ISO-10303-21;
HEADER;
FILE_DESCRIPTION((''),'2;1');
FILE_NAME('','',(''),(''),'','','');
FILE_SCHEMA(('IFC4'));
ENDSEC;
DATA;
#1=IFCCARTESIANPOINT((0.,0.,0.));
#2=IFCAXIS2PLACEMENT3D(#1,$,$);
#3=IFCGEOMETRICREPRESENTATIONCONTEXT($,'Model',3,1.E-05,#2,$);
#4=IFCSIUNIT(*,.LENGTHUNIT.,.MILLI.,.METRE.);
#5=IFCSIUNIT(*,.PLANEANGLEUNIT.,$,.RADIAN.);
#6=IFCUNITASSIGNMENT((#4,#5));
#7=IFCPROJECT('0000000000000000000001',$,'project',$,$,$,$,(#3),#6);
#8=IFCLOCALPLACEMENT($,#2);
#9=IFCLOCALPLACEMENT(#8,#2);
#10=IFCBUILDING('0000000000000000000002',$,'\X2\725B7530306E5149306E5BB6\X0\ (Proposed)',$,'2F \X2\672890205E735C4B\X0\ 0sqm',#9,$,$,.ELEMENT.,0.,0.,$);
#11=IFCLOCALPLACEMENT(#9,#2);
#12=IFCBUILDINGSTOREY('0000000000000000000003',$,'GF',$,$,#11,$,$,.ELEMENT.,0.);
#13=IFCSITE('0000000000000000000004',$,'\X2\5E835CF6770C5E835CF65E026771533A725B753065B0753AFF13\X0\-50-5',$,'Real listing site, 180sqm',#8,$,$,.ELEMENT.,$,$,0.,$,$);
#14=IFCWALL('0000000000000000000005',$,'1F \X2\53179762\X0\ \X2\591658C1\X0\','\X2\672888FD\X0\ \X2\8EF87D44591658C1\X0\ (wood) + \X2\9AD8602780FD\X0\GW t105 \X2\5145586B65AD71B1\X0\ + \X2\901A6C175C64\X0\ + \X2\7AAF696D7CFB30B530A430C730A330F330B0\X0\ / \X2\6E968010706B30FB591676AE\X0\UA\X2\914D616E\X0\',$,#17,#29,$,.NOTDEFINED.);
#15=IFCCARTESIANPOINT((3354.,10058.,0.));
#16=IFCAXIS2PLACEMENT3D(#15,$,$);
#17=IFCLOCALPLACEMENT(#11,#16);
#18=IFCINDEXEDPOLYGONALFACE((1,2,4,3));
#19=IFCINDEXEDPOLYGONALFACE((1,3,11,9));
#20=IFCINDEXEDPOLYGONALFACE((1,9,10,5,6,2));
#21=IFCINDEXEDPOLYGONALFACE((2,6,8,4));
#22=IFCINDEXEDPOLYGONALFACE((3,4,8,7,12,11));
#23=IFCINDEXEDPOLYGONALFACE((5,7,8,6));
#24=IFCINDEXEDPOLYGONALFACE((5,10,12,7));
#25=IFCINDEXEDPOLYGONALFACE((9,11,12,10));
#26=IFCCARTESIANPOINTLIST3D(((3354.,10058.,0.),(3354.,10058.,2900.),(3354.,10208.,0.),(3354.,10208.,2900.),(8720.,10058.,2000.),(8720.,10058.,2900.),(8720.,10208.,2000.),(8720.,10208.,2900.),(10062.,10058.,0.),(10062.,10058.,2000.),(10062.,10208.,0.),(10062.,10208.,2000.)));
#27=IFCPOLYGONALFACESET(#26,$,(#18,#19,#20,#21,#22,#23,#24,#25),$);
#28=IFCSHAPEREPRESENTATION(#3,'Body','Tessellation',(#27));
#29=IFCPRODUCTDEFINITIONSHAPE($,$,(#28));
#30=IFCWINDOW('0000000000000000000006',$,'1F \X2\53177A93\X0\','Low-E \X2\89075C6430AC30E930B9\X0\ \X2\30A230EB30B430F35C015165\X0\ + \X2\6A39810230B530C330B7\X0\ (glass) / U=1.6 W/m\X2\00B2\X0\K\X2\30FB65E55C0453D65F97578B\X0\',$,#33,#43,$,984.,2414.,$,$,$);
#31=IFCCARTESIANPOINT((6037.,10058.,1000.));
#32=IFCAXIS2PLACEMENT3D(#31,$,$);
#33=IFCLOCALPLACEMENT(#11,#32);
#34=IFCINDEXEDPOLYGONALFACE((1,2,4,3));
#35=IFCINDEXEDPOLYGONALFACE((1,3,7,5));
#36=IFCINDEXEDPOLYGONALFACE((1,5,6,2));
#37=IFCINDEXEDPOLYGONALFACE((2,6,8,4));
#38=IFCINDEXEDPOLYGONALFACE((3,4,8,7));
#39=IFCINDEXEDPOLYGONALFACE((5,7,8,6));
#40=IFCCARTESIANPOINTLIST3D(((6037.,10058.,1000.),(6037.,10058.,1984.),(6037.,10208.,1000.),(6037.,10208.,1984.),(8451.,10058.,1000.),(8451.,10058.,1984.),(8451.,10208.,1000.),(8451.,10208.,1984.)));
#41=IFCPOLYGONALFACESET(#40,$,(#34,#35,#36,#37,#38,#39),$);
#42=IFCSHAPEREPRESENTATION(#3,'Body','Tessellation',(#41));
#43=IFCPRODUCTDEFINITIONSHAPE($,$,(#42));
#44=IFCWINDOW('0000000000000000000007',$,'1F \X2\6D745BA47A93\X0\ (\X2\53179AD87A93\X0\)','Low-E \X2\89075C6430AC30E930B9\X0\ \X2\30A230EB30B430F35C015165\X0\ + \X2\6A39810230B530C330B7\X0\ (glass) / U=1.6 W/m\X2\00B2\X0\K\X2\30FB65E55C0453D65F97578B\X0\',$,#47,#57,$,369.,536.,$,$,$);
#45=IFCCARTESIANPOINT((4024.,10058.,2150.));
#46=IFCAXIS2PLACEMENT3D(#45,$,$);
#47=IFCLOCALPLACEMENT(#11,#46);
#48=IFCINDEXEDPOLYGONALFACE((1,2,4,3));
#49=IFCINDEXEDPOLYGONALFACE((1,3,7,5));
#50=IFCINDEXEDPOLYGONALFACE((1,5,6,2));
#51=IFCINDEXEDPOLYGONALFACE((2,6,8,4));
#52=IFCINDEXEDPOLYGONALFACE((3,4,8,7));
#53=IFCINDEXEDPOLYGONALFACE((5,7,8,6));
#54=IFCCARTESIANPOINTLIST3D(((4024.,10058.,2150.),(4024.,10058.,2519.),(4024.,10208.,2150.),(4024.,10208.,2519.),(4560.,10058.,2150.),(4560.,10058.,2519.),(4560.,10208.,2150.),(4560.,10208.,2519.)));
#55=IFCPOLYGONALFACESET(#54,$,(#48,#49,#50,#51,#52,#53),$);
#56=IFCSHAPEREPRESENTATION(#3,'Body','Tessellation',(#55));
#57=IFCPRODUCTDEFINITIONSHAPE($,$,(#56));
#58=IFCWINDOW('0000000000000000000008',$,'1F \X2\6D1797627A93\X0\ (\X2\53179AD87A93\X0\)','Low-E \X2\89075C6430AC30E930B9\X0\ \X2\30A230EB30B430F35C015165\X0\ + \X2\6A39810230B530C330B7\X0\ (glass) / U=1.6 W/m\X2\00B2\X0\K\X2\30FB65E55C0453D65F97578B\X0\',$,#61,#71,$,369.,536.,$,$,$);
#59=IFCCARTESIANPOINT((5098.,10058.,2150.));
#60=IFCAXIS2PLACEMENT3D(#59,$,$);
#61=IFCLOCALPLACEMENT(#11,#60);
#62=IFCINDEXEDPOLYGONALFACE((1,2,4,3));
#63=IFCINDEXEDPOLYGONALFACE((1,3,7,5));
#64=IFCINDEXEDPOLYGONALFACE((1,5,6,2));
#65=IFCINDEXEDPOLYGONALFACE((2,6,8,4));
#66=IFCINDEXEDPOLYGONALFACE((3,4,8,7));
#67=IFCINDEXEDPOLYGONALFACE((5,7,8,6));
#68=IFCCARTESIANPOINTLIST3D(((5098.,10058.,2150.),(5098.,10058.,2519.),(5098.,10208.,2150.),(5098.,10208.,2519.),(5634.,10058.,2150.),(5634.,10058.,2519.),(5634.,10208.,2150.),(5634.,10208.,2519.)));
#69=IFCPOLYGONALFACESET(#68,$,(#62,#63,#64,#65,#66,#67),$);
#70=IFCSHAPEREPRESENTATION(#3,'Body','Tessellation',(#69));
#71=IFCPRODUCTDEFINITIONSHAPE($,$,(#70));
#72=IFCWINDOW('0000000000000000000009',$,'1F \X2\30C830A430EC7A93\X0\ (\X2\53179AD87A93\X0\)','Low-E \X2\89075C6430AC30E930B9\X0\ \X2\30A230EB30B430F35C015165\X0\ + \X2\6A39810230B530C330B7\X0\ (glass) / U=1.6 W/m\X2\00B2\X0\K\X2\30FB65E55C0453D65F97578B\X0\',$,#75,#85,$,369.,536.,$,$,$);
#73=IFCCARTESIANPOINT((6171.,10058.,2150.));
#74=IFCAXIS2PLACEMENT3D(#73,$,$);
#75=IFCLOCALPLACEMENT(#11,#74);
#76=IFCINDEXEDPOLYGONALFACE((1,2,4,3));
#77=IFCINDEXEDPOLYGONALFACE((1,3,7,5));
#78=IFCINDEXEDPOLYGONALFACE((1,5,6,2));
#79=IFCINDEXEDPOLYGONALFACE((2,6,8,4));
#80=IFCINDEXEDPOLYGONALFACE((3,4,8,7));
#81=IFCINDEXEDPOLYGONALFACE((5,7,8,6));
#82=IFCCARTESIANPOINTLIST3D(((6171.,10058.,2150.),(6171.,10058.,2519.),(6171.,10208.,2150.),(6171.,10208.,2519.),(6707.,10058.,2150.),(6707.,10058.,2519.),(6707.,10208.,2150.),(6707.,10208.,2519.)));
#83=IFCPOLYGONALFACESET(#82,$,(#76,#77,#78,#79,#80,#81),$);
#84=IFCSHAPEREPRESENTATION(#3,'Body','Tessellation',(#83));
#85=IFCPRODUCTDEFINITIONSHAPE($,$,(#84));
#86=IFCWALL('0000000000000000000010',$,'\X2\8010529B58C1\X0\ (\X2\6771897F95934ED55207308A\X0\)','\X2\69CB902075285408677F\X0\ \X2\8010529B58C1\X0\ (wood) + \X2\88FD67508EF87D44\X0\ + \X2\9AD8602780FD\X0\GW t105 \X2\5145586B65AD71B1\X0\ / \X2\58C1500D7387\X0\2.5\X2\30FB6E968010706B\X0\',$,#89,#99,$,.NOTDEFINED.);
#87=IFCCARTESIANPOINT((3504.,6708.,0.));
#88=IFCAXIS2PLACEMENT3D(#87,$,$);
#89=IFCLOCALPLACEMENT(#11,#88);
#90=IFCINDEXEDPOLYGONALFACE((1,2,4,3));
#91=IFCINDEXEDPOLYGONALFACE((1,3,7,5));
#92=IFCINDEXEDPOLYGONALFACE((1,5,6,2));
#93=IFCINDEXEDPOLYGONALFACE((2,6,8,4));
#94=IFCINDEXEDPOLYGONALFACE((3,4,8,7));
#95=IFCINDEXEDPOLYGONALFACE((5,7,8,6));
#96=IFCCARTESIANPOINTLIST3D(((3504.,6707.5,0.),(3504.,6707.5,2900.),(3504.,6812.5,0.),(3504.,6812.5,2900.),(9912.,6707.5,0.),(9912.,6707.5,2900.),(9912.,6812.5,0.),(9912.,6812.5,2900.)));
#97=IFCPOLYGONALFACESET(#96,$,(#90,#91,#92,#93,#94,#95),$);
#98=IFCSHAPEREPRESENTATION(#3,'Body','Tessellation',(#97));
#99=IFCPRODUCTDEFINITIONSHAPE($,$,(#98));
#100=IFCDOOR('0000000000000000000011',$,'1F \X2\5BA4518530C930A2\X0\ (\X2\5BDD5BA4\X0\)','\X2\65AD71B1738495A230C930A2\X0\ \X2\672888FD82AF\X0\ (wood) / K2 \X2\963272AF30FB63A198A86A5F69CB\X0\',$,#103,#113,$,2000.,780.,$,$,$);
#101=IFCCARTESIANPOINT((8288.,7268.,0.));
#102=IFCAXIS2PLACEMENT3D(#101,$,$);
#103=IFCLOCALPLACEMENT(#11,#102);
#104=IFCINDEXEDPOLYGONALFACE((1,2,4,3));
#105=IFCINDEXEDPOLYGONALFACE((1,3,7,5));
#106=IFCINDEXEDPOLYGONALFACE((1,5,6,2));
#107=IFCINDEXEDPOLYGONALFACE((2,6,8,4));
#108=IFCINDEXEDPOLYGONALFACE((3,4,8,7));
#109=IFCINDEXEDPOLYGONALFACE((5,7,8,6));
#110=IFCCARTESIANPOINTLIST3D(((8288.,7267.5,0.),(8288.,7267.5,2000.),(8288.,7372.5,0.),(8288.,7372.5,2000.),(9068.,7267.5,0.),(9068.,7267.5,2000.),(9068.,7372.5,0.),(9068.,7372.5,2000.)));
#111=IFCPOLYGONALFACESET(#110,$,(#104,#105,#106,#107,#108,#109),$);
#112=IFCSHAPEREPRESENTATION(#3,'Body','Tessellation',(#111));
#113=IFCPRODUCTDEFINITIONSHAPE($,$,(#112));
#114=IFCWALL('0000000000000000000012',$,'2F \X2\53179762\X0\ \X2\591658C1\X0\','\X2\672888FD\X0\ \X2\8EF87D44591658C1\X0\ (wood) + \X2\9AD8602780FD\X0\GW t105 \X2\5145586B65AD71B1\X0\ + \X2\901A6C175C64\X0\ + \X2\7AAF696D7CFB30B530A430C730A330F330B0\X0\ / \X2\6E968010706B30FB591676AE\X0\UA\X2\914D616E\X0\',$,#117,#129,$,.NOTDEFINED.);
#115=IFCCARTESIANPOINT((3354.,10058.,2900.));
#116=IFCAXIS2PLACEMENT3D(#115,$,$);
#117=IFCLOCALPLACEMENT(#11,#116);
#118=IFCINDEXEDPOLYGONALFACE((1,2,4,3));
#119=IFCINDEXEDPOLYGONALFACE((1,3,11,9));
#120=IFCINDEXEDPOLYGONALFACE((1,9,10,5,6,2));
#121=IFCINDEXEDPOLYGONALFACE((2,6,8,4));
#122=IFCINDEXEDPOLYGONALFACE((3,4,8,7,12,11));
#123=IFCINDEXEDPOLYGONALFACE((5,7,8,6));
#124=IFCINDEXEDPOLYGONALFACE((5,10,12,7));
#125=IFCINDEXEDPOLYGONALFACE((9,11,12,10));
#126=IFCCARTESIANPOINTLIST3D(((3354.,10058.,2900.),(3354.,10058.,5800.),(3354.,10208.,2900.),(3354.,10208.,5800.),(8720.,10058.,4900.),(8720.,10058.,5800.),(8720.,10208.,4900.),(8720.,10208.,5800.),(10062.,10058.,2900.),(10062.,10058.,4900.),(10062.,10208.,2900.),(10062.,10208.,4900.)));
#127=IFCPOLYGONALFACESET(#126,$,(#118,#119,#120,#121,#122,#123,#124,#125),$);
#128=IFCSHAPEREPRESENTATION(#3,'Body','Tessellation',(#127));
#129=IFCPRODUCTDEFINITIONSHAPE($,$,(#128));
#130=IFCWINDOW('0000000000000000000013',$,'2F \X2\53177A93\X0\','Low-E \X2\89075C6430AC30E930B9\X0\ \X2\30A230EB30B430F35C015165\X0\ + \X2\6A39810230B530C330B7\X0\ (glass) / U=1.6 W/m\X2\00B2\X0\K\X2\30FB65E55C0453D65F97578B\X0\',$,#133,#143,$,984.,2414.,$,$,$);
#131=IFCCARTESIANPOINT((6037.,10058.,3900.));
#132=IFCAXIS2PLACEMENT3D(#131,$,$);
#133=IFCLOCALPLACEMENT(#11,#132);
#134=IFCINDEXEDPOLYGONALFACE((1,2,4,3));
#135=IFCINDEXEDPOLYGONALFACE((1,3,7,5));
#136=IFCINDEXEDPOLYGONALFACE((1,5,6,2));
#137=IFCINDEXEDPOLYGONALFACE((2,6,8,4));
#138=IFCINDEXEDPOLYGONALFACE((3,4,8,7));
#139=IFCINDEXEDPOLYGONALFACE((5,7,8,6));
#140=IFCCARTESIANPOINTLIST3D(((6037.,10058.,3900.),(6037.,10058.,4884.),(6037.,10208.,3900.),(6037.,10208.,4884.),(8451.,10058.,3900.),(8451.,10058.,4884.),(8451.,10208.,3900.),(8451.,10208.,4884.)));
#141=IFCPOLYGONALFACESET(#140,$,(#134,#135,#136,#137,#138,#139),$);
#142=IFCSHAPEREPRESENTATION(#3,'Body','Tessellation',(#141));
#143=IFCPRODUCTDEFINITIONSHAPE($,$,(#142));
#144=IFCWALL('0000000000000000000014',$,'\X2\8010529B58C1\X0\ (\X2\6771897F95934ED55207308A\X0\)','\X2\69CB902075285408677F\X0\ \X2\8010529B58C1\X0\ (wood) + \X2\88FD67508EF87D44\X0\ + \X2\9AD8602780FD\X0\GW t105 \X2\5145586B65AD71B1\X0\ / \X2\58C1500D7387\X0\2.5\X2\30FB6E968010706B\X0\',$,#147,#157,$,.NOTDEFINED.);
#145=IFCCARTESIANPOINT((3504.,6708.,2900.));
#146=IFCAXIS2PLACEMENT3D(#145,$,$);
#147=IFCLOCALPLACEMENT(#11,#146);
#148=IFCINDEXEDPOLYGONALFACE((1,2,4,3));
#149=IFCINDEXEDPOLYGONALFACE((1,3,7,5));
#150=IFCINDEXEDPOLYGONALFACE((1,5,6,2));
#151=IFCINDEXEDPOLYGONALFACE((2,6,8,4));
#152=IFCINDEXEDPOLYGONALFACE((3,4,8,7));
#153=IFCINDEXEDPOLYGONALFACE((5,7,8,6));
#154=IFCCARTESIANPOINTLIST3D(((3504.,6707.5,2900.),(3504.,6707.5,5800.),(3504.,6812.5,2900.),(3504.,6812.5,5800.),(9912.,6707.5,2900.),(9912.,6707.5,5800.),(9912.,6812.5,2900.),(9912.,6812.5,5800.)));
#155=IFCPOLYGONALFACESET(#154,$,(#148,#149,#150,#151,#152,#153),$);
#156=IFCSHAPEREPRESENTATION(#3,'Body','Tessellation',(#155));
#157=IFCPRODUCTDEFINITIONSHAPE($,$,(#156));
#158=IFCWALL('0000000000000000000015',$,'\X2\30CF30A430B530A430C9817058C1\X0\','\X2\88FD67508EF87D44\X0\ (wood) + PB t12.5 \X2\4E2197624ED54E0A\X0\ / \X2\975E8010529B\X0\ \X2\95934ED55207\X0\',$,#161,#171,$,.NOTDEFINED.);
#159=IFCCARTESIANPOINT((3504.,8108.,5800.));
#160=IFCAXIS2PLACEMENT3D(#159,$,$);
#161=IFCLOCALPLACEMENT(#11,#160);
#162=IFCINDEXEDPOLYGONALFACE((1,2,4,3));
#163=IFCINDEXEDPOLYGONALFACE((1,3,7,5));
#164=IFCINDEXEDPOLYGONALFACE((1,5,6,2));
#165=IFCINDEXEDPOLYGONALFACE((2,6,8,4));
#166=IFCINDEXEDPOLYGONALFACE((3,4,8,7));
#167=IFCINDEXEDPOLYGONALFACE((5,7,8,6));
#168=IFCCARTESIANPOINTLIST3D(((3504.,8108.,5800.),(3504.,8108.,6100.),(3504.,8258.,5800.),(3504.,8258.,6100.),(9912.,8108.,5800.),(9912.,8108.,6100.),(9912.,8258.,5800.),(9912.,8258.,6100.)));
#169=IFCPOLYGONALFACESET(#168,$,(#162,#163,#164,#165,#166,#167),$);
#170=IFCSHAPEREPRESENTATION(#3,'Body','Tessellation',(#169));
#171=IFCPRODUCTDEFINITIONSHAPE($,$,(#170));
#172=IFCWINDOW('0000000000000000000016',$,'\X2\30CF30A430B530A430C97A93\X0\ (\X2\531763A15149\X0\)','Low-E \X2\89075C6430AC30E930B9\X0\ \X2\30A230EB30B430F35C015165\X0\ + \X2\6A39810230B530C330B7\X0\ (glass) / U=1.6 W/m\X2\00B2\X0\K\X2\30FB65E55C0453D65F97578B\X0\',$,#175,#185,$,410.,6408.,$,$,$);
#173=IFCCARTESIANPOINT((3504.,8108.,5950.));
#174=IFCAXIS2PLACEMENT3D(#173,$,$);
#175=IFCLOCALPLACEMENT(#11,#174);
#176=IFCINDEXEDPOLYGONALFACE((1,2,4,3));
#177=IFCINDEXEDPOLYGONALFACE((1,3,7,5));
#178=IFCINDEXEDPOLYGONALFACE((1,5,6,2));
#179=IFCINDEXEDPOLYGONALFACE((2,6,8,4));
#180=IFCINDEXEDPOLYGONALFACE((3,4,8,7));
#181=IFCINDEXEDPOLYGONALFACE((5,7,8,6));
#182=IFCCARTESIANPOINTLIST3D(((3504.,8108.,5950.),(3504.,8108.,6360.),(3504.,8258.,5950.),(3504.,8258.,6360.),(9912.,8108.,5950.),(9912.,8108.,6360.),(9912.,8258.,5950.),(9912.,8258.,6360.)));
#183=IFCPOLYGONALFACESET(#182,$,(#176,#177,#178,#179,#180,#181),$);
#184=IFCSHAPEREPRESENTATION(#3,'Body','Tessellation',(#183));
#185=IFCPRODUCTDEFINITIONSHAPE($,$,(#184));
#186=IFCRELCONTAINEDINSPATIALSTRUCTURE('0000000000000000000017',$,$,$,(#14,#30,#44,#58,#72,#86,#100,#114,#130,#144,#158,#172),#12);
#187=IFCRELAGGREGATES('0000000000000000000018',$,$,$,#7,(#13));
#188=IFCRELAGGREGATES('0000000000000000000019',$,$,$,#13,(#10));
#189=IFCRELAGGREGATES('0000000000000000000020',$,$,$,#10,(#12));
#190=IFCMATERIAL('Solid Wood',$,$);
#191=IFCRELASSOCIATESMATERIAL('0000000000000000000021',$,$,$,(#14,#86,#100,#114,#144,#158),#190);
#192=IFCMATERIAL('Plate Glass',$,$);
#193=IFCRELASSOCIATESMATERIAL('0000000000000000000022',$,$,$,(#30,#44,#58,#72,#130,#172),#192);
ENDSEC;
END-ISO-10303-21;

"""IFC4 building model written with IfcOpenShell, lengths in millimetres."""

from ifc_helpers import new_model, si_unit, frame, frame_2d, origin, place, context, project, spatial, rectangle, extrude, material, element, fill, save


model = new_model("IFC4")

# Units and contexts
model_context = context("Model", 3, precision=1e-05, world=origin())
ifc_project = project(units=[si_unit("LENGTHUNIT", "METRE", prefix="MILLI"), si_unit("PLANEANGLEUNIT", "RADIAN")], contexts=[model_context])

# Site, building, storey
site_placement = place(None, origin())
site = spatial("IfcSite", under=ifc_project, at=site_placement, Name="広島県広島市東区牛田新町３-50-5", ObjectType="Real listing site, 180sqm", CompositionType="ELEMENT", RefElevation=0.0)
building_placement = place(site_placement, origin())
building = spatial("IfcBuilding", under=site, at=building_placement, Name="牛田の光の家 (Proposed)", ObjectType="2F 木造平屋 0sqm", CompositionType="ELEMENT", ElevationOfRefHeight=0.0, ElevationOfTerrain=0.0)
storey_placement = place(building_placement, origin())
storey = spatial("IfcBuildingStorey", under=building, at=storey_placement, Name="GF", CompositionType="ELEMENT", Elevation=0.0)

# Wall, openings, windows
ifc_material_1 = material(Name="Solid Wood")
wall_1_placement = place(storey_placement, frame((3354.0, 10058.0, 0.0)))
wall_1 = element("IfcWall", 1, at=wall_1_placement, inside=storey, material=ifc_material_1, Name="1F 北面 外壁", Description="木製 軸組外壁 (wood) + 高性能GW t105 充填断熱 + 通気層 + 窯業系サイディング / 準耐火・外皮UA配慮", PredefinedType="NOTDEFINED", context=model_context, shape_type="SweptSolid", body=[
    extrude(rectangle(XDim=6708.0, YDim=150.0, at=frame_2d((3354.0, 75.0))), frame((3354.0, 10058.0, 0.0)), (0.0, 0.0, 1.0), 2900.0),
])
opening_1_placement = place(storey_placement, frame((6037.0, 10058.0, 1000.0)))
opening_1 = element("IfcOpeningElement", 2, at=opening_1_placement, cuts=wall_1, PredefinedType="NOTDEFINED", context=model_context, shape_type="SweptSolid", body=[
    extrude(rectangle(XDim=2414.0, YDim=150.0, at=frame_2d((1207.0, 75.0))), frame((6037.0, 10058.0, 1000.0)), (0.0, 0.0, 1.0), 984.0),
])
opening_2_placement = place(storey_placement, frame((4024.0, 10058.0, 2150.0)))
opening_2 = element("IfcOpeningElement", 3, at=opening_2_placement, cuts=wall_1, PredefinedType="NOTDEFINED", context=model_context, shape_type="SweptSolid", body=[
    extrude(rectangle(XDim=536.0, YDim=150.0, at=frame_2d((268.0, 75.0))), frame((4024.0, 10058.0, 2150.0)), (0.0, 0.0, 1.0), 369.0),
])
opening_3_placement = place(storey_placement, frame((5098.0, 10058.0, 2150.0)))
opening_3 = element("IfcOpeningElement", 4, at=opening_3_placement, cuts=wall_1, PredefinedType="NOTDEFINED", context=model_context, shape_type="SweptSolid", body=[
    extrude(rectangle(XDim=536.0, YDim=150.0, at=frame_2d((268.0, 75.0))), frame((5098.0, 10058.0, 2150.0)), (0.0, 0.0, 1.0), 369.0),
])
opening_4_placement = place(storey_placement, frame((6171.0, 10058.0, 2150.0)))
opening_4 = element("IfcOpeningElement", 5, at=opening_4_placement, cuts=wall_1, PredefinedType="NOTDEFINED", context=model_context, shape_type="SweptSolid", body=[
    extrude(rectangle(XDim=536.0, YDim=150.0, at=frame_2d((268.0, 75.0))), frame((6171.0, 10058.0, 2150.0)), (0.0, 0.0, 1.0), 369.0),
])
ifc_material_2 = material(Name="Plate Glass")
window_1_placement = place(storey_placement, frame((6037.0, 10058.0, 1000.0)))
window_1 = element("IfcWindow", 6, at=window_1_placement, inside=storey, material=ifc_material_2, Name="1F 北窓", Description="Low-E 複層ガラス アルゴン封入 + 樹脂サッシ (glass) / U=1.6 W/m²K・日射取得型", OverallHeight=984.0, OverallWidth=2414.0, context=model_context, shape_type="SweptSolid", body=[
    extrude(rectangle(XDim=2414.0, YDim=150.0, at=frame_2d((1207.0, 75.0))), frame((6037.0, 10058.0, 1000.0)), (0.0, 0.0, 1.0), 984.0),
])
fill(opening_1, window_1)
window_2_placement = place(storey_placement, frame((4024.0, 10058.0, 2150.0)))
window_2 = element("IfcWindow", 7, at=window_2_placement, inside=storey, material=ifc_material_2, Name="1F 浴室窓 (北高窓)", Description="Low-E 複層ガラス アルゴン封入 + 樹脂サッシ (glass) / U=1.6 W/m²K・日射取得型", OverallHeight=369.0, OverallWidth=536.0, context=model_context, shape_type="SweptSolid", body=[
    extrude(rectangle(XDim=536.0, YDim=150.0, at=frame_2d((268.0, 75.0))), frame((4024.0, 10058.0, 2150.0)), (0.0, 0.0, 1.0), 369.0),
])
fill(opening_2, window_2)
window_3_placement = place(storey_placement, frame((5098.0, 10058.0, 2150.0)))
window_3 = element("IfcWindow", 8, at=window_3_placement, inside=storey, material=ifc_material_2, Name="1F 洗面窓 (北高窓)", Description="Low-E 複層ガラス アルゴン封入 + 樹脂サッシ (glass) / U=1.6 W/m²K・日射取得型", OverallHeight=369.0, OverallWidth=536.0, context=model_context, shape_type="SweptSolid", body=[
    extrude(rectangle(XDim=536.0, YDim=150.0, at=frame_2d((268.0, 75.0))), frame((5098.0, 10058.0, 2150.0)), (0.0, 0.0, 1.0), 369.0),
])
fill(opening_3, window_3)
window_4_placement = place(storey_placement, frame((6171.0, 10058.0, 2150.0)))
window_4 = element("IfcWindow", 9, at=window_4_placement, inside=storey, material=ifc_material_2, Name="1F トイレ窓 (北高窓)", Description="Low-E 複層ガラス アルゴン封入 + 樹脂サッシ (glass) / U=1.6 W/m²K・日射取得型", OverallHeight=369.0, OverallWidth=536.0, context=model_context, shape_type="SweptSolid", body=[
    extrude(rectangle(XDim=536.0, YDim=150.0, at=frame_2d((268.0, 75.0))), frame((6171.0, 10058.0, 2150.0)), (0.0, 0.0, 1.0), 369.0),
])
fill(opening_4, window_4)

# Wall
wall_2_placement = place(storey_placement, frame((3504.0, 6708.0, 0.0)))
element("IfcWall", 10, at=wall_2_placement, inside=storey, material=ifc_material_1, Name="耐力壁 (東西間仕切り)", Description="構造用合板 耐力壁 (wood) + 製材軸組 + 高性能GW t105 充填断熱 / 壁倍率2.5・準耐火", PredefinedType="NOTDEFINED", context=model_context, shape_type="SweptSolid", body=[
    extrude(rectangle(XDim=6408.0, YDim=105.0, at=frame_2d((3204.0, 52.0))), frame((3504.0, 6708.0, 0.0)), (0.0, 0.0, 1.0), 2900.0),
])

# Door
door_1_placement = place(storey_placement, frame((8288.0, 7268.0, 0.0)))
element("IfcDoor", 11, at=door_1_placement, inside=storey, material=ifc_material_1, Name="1F 室内ドア (寝室)", Description="断熱玄関ドア 木製芯 (wood) / K2 防犯・採風機構", OverallHeight=2000.0, OverallWidth=780.0, context=model_context, shape_type="SweptSolid", body=[
    extrude(rectangle(XDim=780.0, YDim=105.0, at=frame_2d((390.0, 52.0))), frame((8288.0, 7268.0, 0.0)), (0.0, 0.0, 1.0), 2000.0),
])

# Wall, opening, window
wall_3_placement = place(storey_placement, frame((3354.0, 10058.0, 2900.0)))
wall_3 = element("IfcWall", 12, at=wall_3_placement, inside=storey, material=ifc_material_1, Name="2F 北面 外壁", Description="木製 軸組外壁 (wood) + 高性能GW t105 充填断熱 + 通気層 + 窯業系サイディング / 準耐火・外皮UA配慮", PredefinedType="NOTDEFINED", context=model_context, shape_type="SweptSolid", body=[
    extrude(rectangle(XDim=6708.0, YDim=150.0, at=frame_2d((3354.0, 75.0))), frame((3354.0, 10058.0, 2900.0)), (0.0, 0.0, 1.0), 2900.0),
])
opening_5_placement = place(storey_placement, frame((6037.0, 10058.0, 3900.0)))
opening_5 = element("IfcOpeningElement", 13, at=opening_5_placement, cuts=wall_3, PredefinedType="NOTDEFINED", context=model_context, shape_type="SweptSolid", body=[
    extrude(rectangle(XDim=2414.0, YDim=150.0, at=frame_2d((1207.0, 75.0))), frame((6037.0, 10058.0, 3900.0)), (0.0, 0.0, 1.0), 984.0),
])
window_5_placement = place(storey_placement, frame((6037.0, 10058.0, 3900.0)))
window_5 = element("IfcWindow", 14, at=window_5_placement, inside=storey, material=ifc_material_2, Name="2F 北窓", Description="Low-E 複層ガラス アルゴン封入 + 樹脂サッシ (glass) / U=1.6 W/m²K・日射取得型", OverallHeight=984.0, OverallWidth=2414.0, context=model_context, shape_type="SweptSolid", body=[
    extrude(rectangle(XDim=2414.0, YDim=150.0, at=frame_2d((1207.0, 75.0))), frame((6037.0, 10058.0, 3900.0)), (0.0, 0.0, 1.0), 984.0),
])
fill(opening_5, window_5)

# Wall
wall_4_placement = place(storey_placement, frame((3504.0, 6708.0, 2900.0)))
element("IfcWall", 15, at=wall_4_placement, inside=storey, material=ifc_material_1, Name="耐力壁 (東西間仕切り)", Description="構造用合板 耐力壁 (wood) + 製材軸組 + 高性能GW t105 充填断熱 / 壁倍率2.5・準耐火", PredefinedType="NOTDEFINED", context=model_context, shape_type="SweptSolid", body=[
    extrude(rectangle(XDim=6408.0, YDim=105.0, at=frame_2d((3204.0, 52.0))), frame((3504.0, 6708.0, 2900.0)), (0.0, 0.0, 1.0), 2900.0),
])

# Wall, opening, window
wall_5_placement = place(storey_placement, frame((3504.0, 8108.0, 5800.0)))
wall_5 = element("IfcWall", 16, at=wall_5_placement, inside=storey, material=ifc_material_1, Name="ハイサイド腰壁", Description="製材軸組 (wood) + PB t12.5 両面仕上 / 非耐力 間仕切", PredefinedType="NOTDEFINED", context=model_context, shape_type="SweptSolid", body=[
    extrude(rectangle(XDim=6408.0, YDim=150.0, at=frame_2d((3204.0, 75.0))), frame((3504.0, 8108.0, 5800.0)), (0.0, 0.0, 1.0), 700.0),
])
opening_6_placement = place(storey_placement, frame((3504.0, 8108.0, 5950.0)))
opening_6 = element("IfcOpeningElement", 17, at=opening_6_placement, cuts=wall_5, PredefinedType="NOTDEFINED", context=model_context, shape_type="SweptSolid", body=[
    extrude(rectangle(XDim=6408.0, YDim=150.0, at=frame_2d((3204.0, 75.0))), frame((3504.0, 8108.0, 5950.0)), (0.0, 0.0, 1.0), 410.0),
])
window_6_placement = place(storey_placement, frame((3504.0, 8108.0, 5950.0)))
window_6 = element("IfcWindow", 18, at=window_6_placement, inside=storey, material=ifc_material_2, Name="ハイサイド窓 (北採光)", Description="Low-E 複層ガラス アルゴン封入 + 樹脂サッシ (glass) / U=1.6 W/m²K・日射取得型", OverallHeight=410.0, OverallWidth=6408.0, context=model_context, shape_type="SweptSolid", body=[
    extrude(rectangle(XDim=6408.0, YDim=150.0, at=frame_2d((3204.0, 75.0))), frame((3504.0, 8108.0, 5950.0)), (0.0, 0.0, 1.0), 410.0),
])
fill(opening_6, window_6)

save(model, "model.ifc")
